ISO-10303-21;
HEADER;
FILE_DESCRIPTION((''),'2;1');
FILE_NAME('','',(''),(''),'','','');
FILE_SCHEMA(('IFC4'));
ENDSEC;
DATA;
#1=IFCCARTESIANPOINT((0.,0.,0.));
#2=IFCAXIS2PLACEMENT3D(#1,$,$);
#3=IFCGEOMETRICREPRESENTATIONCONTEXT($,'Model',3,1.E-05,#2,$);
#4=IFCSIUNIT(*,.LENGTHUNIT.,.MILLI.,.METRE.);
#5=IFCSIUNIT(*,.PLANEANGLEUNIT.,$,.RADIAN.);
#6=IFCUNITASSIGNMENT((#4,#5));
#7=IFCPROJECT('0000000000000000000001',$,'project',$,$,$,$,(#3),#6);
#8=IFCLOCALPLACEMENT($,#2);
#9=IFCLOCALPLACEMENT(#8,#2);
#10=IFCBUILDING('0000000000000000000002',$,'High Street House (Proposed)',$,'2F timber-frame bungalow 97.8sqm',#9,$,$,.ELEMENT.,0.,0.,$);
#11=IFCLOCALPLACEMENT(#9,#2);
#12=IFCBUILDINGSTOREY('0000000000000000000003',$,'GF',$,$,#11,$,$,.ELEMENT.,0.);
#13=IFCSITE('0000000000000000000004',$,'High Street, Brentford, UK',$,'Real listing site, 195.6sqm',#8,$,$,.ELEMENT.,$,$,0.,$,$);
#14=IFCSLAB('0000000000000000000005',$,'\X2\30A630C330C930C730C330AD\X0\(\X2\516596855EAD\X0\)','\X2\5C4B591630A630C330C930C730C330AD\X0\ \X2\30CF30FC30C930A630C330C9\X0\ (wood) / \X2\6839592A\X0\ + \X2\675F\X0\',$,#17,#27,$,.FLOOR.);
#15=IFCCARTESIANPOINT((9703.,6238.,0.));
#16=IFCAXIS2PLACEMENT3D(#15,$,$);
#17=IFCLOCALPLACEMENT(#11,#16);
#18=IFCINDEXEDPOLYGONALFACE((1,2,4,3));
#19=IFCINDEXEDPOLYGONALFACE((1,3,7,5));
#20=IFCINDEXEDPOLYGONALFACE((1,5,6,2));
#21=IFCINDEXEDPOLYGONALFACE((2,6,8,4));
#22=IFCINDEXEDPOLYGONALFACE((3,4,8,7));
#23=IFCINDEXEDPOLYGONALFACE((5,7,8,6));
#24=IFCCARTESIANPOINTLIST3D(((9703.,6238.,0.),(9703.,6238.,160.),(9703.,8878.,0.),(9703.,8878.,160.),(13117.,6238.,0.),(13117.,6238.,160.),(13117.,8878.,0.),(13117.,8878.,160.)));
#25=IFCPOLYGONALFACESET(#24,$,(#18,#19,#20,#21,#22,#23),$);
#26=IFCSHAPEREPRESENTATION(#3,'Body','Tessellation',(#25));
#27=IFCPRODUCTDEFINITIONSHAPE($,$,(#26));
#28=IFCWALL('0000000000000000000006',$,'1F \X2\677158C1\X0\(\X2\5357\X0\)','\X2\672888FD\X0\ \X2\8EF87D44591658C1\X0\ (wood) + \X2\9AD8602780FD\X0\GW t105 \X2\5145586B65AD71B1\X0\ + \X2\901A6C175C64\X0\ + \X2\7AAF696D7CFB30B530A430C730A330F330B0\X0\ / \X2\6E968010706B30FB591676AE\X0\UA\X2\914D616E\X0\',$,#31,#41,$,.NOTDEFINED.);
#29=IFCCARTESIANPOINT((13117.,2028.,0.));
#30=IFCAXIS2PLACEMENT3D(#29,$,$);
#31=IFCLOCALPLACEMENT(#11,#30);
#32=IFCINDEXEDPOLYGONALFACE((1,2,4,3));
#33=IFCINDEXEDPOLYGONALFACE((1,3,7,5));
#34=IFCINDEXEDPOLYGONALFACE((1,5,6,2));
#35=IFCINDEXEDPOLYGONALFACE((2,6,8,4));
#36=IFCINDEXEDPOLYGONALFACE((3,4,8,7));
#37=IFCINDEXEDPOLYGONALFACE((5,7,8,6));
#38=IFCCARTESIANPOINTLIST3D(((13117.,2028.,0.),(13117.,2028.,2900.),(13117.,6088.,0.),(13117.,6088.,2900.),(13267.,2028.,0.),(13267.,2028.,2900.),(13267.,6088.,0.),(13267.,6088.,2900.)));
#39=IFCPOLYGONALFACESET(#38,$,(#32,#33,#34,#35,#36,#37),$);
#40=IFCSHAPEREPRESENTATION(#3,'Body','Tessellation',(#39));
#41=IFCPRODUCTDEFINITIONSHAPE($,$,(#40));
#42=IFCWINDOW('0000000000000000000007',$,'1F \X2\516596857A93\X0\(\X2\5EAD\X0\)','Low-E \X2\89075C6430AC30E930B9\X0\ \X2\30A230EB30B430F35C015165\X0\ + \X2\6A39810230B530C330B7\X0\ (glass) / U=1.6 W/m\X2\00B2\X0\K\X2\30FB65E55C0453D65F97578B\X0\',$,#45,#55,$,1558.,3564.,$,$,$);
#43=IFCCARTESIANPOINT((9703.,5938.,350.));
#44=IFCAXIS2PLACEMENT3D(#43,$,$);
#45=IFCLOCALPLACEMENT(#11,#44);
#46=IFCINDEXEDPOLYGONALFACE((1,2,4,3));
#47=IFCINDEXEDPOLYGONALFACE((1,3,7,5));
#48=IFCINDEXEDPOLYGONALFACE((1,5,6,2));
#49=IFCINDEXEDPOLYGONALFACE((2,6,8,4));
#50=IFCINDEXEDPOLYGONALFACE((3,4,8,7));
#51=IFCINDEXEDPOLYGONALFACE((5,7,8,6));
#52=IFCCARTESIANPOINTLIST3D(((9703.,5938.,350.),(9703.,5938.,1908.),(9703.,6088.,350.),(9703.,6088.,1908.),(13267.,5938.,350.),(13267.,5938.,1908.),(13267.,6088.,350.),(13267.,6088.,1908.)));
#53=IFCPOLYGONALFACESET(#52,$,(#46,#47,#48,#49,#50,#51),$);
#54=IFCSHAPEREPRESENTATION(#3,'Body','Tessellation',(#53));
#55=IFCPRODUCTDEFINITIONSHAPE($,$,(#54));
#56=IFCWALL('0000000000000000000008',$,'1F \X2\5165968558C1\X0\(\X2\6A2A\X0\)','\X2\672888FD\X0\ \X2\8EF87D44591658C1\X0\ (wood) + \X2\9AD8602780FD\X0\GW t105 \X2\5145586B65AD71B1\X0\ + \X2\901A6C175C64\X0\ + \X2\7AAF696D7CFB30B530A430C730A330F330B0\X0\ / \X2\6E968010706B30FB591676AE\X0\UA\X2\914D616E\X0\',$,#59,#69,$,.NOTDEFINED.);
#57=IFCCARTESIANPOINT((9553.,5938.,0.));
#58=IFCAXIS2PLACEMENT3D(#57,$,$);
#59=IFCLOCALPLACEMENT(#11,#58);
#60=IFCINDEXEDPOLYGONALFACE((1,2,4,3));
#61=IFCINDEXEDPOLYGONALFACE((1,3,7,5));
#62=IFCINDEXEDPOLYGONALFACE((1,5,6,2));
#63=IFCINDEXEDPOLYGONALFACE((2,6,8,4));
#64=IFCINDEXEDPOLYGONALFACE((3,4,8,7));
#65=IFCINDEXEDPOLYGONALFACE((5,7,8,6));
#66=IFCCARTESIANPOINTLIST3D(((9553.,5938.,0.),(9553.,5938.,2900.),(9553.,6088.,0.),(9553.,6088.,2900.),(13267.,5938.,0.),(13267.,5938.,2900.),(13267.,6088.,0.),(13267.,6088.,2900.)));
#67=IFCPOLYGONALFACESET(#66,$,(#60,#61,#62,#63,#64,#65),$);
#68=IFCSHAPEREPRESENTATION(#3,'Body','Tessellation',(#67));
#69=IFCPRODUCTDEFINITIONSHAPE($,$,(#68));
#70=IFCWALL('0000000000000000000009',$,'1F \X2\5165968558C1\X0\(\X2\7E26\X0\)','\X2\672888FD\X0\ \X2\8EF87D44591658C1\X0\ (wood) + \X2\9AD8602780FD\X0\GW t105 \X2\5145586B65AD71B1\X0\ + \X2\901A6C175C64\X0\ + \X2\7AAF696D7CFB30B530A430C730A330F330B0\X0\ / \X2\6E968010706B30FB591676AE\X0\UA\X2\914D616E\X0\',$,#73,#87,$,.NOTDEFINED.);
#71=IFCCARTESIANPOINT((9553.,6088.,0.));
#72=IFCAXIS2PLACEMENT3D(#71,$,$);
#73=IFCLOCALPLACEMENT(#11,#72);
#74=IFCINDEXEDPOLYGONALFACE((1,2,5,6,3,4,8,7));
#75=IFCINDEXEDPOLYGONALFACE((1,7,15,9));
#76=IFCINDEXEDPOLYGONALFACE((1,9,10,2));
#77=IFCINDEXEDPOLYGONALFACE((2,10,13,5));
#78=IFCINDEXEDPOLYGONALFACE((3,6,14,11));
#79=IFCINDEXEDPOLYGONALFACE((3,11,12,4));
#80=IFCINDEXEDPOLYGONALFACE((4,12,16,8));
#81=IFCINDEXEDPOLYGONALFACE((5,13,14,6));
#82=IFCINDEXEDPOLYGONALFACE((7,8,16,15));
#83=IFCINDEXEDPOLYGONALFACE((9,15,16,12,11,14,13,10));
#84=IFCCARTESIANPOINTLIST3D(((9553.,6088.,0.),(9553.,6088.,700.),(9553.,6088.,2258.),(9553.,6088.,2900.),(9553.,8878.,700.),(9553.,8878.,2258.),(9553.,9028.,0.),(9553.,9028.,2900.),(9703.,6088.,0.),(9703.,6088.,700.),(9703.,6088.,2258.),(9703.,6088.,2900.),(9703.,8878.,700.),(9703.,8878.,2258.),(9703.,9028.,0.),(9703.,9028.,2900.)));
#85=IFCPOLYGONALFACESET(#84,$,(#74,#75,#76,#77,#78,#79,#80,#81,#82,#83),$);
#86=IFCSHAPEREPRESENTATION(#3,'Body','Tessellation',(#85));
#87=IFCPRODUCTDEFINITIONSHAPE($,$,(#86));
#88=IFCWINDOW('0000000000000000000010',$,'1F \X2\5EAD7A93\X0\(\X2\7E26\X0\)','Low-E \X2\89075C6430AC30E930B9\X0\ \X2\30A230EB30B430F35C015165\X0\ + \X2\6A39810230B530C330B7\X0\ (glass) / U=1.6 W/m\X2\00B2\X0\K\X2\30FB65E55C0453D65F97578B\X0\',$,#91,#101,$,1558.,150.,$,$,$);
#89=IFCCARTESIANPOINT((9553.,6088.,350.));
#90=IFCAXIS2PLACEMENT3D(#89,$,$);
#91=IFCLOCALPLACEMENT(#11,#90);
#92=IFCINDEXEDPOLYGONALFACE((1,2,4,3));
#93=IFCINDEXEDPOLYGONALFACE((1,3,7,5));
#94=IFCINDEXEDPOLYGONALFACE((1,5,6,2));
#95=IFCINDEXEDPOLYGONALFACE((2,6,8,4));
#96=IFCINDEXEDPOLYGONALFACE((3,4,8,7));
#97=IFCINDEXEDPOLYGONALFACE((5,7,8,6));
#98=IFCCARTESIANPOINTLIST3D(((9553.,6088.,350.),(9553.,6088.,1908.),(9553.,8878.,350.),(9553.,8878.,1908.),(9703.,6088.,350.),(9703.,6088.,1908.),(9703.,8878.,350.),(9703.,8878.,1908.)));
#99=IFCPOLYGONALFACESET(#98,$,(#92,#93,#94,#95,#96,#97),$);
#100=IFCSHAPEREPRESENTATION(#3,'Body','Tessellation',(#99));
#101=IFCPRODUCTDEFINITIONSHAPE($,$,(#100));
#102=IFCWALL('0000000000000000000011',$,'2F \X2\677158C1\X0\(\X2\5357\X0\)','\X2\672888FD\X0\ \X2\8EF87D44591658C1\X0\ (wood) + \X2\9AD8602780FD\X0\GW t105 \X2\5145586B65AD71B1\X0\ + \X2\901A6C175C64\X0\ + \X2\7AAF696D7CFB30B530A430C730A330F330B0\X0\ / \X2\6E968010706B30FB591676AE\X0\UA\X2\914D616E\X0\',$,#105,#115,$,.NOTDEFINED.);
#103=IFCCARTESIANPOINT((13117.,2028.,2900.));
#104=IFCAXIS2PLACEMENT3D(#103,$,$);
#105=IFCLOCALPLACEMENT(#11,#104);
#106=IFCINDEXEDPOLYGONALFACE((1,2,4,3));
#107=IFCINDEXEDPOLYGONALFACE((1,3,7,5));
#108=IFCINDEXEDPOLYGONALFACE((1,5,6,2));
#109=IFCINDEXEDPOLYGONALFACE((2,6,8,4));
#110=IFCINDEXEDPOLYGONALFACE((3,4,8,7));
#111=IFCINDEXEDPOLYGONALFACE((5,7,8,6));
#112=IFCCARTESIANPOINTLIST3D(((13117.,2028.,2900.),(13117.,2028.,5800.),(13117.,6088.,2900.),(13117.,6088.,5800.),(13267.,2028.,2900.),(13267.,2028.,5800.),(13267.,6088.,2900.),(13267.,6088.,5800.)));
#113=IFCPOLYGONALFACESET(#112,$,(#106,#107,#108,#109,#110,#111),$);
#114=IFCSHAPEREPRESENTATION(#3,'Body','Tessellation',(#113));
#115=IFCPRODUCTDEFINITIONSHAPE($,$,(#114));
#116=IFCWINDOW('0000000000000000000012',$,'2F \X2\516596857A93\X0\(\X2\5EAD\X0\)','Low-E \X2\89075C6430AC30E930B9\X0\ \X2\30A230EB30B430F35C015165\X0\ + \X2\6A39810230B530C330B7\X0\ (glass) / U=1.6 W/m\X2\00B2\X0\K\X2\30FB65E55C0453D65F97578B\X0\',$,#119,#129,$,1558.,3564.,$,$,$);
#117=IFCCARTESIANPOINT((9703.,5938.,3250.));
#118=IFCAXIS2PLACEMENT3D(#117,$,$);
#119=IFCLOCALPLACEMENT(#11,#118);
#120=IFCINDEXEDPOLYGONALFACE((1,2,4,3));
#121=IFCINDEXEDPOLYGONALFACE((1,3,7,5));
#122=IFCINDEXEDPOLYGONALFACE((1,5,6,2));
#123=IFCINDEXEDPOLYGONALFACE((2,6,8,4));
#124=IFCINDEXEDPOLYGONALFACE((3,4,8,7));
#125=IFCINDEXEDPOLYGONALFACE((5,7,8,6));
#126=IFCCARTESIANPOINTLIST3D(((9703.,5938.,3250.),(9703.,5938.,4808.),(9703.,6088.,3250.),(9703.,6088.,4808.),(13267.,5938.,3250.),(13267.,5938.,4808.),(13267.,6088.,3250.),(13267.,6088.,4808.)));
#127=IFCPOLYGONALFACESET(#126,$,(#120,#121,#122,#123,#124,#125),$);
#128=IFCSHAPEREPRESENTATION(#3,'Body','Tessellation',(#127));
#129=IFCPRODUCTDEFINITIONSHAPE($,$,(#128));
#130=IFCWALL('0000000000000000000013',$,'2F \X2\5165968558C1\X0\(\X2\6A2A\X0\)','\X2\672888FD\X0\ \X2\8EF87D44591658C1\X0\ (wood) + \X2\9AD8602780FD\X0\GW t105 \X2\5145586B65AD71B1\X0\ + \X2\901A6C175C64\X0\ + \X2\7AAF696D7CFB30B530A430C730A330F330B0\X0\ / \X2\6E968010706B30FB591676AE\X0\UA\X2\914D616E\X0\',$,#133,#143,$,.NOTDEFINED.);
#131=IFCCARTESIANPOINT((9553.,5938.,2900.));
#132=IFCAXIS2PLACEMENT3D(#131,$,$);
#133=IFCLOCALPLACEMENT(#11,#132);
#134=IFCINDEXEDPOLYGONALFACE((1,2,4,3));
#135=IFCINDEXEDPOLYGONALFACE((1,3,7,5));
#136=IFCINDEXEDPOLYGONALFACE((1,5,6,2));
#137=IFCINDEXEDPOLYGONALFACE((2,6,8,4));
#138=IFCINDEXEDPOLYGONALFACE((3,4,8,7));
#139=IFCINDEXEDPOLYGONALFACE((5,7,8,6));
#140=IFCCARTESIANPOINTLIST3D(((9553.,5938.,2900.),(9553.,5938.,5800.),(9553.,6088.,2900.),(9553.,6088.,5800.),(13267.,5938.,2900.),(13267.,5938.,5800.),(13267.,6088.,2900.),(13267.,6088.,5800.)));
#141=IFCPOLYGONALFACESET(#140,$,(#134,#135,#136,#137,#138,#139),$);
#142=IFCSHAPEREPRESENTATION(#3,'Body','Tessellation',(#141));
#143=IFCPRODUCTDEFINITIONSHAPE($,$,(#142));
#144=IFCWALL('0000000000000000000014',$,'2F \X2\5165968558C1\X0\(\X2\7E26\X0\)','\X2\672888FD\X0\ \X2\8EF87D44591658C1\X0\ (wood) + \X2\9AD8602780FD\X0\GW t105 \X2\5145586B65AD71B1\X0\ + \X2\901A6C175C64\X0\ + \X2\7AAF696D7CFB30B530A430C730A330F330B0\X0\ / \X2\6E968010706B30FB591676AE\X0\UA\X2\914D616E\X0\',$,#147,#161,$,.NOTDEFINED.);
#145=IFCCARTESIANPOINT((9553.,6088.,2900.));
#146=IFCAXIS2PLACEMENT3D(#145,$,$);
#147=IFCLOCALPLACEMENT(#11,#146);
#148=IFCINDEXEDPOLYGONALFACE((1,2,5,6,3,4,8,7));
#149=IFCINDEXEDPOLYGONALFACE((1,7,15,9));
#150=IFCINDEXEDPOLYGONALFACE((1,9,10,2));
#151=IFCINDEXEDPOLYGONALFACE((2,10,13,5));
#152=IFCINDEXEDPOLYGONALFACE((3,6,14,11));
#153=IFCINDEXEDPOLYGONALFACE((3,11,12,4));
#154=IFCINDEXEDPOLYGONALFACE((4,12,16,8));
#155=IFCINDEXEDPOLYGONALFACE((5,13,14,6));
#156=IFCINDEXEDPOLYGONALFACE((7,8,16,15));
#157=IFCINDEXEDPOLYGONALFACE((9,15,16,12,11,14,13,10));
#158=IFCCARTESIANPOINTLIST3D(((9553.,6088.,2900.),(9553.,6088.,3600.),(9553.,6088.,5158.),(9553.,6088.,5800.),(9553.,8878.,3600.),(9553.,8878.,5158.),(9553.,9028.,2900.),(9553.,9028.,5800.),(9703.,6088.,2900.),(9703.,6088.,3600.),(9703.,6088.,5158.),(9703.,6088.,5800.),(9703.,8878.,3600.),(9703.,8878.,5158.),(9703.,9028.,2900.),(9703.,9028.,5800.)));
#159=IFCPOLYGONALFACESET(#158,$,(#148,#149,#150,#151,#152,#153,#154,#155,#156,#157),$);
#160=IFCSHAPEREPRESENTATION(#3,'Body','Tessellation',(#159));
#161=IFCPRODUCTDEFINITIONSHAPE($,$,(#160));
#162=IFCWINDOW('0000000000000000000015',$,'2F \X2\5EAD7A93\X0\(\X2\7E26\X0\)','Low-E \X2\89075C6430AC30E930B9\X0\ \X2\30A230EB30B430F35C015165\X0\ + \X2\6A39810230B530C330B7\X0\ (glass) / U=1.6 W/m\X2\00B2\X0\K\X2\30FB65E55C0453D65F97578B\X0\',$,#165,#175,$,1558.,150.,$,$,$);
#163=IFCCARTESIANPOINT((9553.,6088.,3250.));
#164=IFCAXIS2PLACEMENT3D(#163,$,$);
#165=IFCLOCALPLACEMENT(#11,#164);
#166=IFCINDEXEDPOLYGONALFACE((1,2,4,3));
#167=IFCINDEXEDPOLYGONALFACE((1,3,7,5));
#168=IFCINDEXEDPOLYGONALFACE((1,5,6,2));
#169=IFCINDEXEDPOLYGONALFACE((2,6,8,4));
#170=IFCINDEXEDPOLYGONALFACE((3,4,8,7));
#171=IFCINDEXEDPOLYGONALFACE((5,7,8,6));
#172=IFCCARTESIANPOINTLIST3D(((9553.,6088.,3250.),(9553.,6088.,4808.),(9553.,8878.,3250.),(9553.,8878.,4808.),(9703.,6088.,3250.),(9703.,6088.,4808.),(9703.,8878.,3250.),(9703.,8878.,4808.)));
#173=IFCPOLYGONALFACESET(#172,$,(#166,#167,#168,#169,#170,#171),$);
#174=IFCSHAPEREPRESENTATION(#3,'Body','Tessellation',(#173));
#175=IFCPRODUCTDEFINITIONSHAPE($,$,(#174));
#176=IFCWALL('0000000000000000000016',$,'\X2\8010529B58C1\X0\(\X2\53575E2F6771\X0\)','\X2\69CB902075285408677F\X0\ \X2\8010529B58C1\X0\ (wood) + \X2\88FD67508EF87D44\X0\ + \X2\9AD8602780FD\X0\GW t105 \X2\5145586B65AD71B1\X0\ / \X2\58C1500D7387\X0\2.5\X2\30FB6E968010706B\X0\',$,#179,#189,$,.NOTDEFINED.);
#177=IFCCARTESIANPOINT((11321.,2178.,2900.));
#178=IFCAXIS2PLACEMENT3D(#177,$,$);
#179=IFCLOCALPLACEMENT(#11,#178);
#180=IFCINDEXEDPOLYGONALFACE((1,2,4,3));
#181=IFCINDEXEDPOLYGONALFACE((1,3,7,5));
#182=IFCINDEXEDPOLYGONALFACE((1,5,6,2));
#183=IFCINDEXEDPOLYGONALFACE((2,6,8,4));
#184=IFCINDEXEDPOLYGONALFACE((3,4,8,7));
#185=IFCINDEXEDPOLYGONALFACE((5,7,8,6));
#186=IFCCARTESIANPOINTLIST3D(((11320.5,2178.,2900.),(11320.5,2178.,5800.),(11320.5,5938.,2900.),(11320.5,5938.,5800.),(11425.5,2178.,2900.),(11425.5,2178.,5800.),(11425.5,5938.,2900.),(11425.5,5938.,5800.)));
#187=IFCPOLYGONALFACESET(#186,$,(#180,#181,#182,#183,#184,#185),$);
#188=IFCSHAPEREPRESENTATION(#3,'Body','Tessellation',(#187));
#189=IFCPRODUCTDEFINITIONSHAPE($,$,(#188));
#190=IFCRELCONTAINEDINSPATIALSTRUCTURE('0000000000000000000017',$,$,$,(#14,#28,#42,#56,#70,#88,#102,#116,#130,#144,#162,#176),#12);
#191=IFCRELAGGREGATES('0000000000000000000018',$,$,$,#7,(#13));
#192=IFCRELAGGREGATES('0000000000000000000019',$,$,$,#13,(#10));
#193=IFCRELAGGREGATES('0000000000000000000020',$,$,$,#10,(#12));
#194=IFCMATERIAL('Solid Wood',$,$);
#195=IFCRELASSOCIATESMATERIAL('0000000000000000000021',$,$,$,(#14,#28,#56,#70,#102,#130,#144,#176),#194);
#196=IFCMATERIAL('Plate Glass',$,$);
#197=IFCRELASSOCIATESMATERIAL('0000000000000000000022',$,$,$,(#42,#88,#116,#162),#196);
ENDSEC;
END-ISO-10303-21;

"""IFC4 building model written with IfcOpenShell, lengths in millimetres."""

from ifc_helpers import new_model, si_unit, frame, frame_2d, origin, place, context, project, spatial, rectangle, extrude, material, element, fill, save


model = new_model("IFC4")

# Units and contexts
model_context = context("Model", 3, precision=1e-05, world=origin())
ifc_project = project(units=[si_unit("LENGTHUNIT", "METRE", prefix="MILLI"), si_unit("PLANEANGLEUNIT", "RADIAN")], contexts=[model_context])

# Site, building, storey
site_placement = place(None, origin())
site = spatial("IfcSite", under=ifc_project, at=site_placement, Name="High Street, Brentford, UK", ObjectType="Real listing site, 195.6sqm", CompositionType="ELEMENT", RefElevation=0.0)
building_placement = place(site_placement, origin())
building = spatial("IfcBuilding", under=site, at=building_placement, Name="High Street House (Proposed)", ObjectType="2F timber-frame bungalow 97.8sqm", CompositionType="ELEMENT", ElevationOfRefHeight=0.0, ElevationOfTerrain=0.0)
storey_placement = place(building_placement, origin())
storey = spatial("IfcBuildingStorey", under=building, at=storey_placement, Name="GF", CompositionType="ELEMENT", Elevation=0.0)

# Slab
ifc_material_1 = material(Name="Solid Wood")
slab_placement = place(storey_placement, frame((9703.0, 6238.0, 0.0)))
element("IfcSlab", 1, at=slab_placement, inside=storey, material=ifc_material_1, Name="ウッドデッキ(入隅庭)", Description="屋外ウッドデッキ ハードウッド (wood) / 根太 + 束", PredefinedType="FLOOR", context=model_context, shape_type="SweptSolid", body=[
    extrude(rectangle(XDim=3414.0, YDim=2640.0, at=frame_2d((1707.0, 1320.0))), frame((9703.0, 6238.0, 0.0)), (0.0, 0.0, 1.0), 160.0),
])

# Wall, opening, window
wall_1_placement = place(storey_placement, frame((13117.0, 2028.0, 0.0)))
wall_1 = element("IfcWall", 2, at=wall_1_placement, inside=storey, material=ifc_material_1, Name="1F 東壁(南)", Description="木製 軸組外壁 (wood) + 高性能GW t105 充填断熱 + 通気層 + 窯業系サイディング / 準耐火・外皮UA配慮", PredefinedType="NOTDEFINED", context=model_context, shape_type="SweptSolid", body=[
    extrude(rectangle(XDim=150.0, YDim=4060.0, at=frame_2d((75.0, 2030.0))), frame((13117.0, 2028.0, 0.0)), (0.0, 0.0, 1.0), 2900.0),
])
opening_1_placement = place(storey_placement, frame((9703.0, 5938.0, 350.0)))
opening_1 = element("IfcOpeningElement", 3, at=opening_1_placement, cuts=wall_1, PredefinedType="NOTDEFINED", context=model_context, shape_type="SweptSolid", body=[
    extrude(rectangle(XDim=3564.0, YDim=150.0, at=frame_2d((1782.0, 75.0))), frame((9703.0, 5938.0, 350.0)), (0.0, 0.0, 1.0), 1558.0),
])
ifc_material_2 = material(Name="Plate Glass")
window_1_placement = place(storey_placement, frame((9703.0, 5938.0, 350.0)))
window_1 = element("IfcWindow", 4, at=window_1_placement, inside=storey, material=ifc_material_2, Name="1F 入隅窓(庭)", Description="Low-E 複層ガラス アルゴン封入 + 樹脂サッシ (glass) / U=1.6 W/m²K・日射取得型", OverallHeight=1558.0, OverallWidth=3564.0, context=model_context, shape_type="SweptSolid", body=[
    extrude(rectangle(XDim=3564.0, YDim=150.0, at=frame_2d((1782.0, 75.0))), frame((9703.0, 5938.0, 350.0)), (0.0, 0.0, 1.0), 1558.0),
])
fill(opening_1, window_1)

# Wall
wall_2_placement = place(storey_placement, frame((9553.0, 5938.0, 0.0)))
element("IfcWall", 5, at=wall_2_placement, inside=storey, material=ifc_material_1, Name="1F 入隅壁(横)", Description="木製 軸組外壁 (wood) + 高性能GW t105 充填断熱 + 通気層 + 窯業系サイディング / 準耐火・外皮UA配慮", PredefinedType="NOTDEFINED", context=model_context, shape_type="SweptSolid", body=[
    extrude(rectangle(XDim=3714.0, YDim=150.0, at=frame_2d((1857.0, 75.0))), frame((9553.0, 5938.0, 0.0)), (0.0, 0.0, 1.0), 2900.0),
])

# Wall, opening, window
wall_3_placement = place(storey_placement, frame((9553.0, 6088.0, 0.0)))
wall_3 = element("IfcWall", 6, at=wall_3_placement, inside=storey, material=ifc_material_1, Name="1F 入隅壁(縦)", Description="木製 軸組外壁 (wood) + 高性能GW t105 充填断熱 + 通気層 + 窯業系サイディング / 準耐火・外皮UA配慮", PredefinedType="NOTDEFINED", context=model_context, shape_type="SweptSolid", body=[
    extrude(rectangle(XDim=150.0, YDim=2940.0, at=frame_2d((75.0, 1470.0))), frame((9553.0, 6088.0, 0.0)), (0.0, 0.0, 1.0), 2900.0),
])
opening_2_placement = place(storey_placement, frame((9553.0, 6088.0, 350.0)))
opening_2 = element("IfcOpeningElement", 7, at=opening_2_placement, cuts=wall_3, PredefinedType="NOTDEFINED", context=model_context, shape_type="SweptSolid", body=[
    extrude(rectangle(XDim=150.0, YDim=2790.0, at=frame_2d((75.0, 1395.0))), frame((9553.0, 6088.0, 350.0)), (0.0, 0.0, 1.0), 1558.0),
])
window_2_placement = place(storey_placement, frame((9553.0, 6088.0, 350.0)))
window_2 = element("IfcWindow", 8, at=window_2_placement, inside=storey, material=ifc_material_2, Name="1F 庭窓(縦)", Description="Low-E 複層ガラス アルゴン封入 + 樹脂サッシ (glass) / U=1.6 W/m²K・日射取得型", OverallHeight=1558.0, OverallWidth=150.0, context=model_context, shape_type="SweptSolid", body=[
    extrude(rectangle(XDim=150.0, YDim=2790.0, at=frame_2d((75.0, 1395.0))), frame((9553.0, 6088.0, 350.0)), (0.0, 0.0, 1.0), 1558.0),
])
fill(opening_2, window_2)

# Wall, opening, window
wall_4_placement = place(storey_placement, frame((13117.0, 2028.0, 2900.0)))
wall_4 = element("IfcWall", 9, at=wall_4_placement, inside=storey, material=ifc_material_1, Name="2F 東壁(南)", Description="木製 軸組外壁 (wood) + 高性能GW t105 充填断熱 + 通気層 + 窯業系サイディング / 準耐火・外皮UA配慮", PredefinedType="NOTDEFINED", context=model_context, shape_type="SweptSolid", body=[
    extrude(rectangle(XDim=150.0, YDim=4060.0, at=frame_2d((75.0, 2030.0))), frame((13117.0, 2028.0, 2900.0)), (0.0, 0.0, 1.0), 2900.0),
])
opening_3_placement = place(storey_placement, frame((9703.0, 5938.0, 3250.0)))
opening_3 = element("IfcOpeningElement", 10, at=opening_3_placement, cuts=wall_4, PredefinedType="NOTDEFINED", context=model_context, shape_type="SweptSolid", body=[
    extrude(rectangle(XDim=3564.0, YDim=150.0, at=frame_2d((1782.0, 75.0))), frame((9703.0, 5938.0, 3250.0)), (0.0, 0.0, 1.0), 1558.0),
])
window_3_placement = place(storey_placement, frame((9703.0, 5938.0, 3250.0)))
window_3 = element("IfcWindow", 11, at=window_3_placement, inside=storey, material=ifc_material_2, Name="2F 入隅窓(庭)", Description="Low-E 複層ガラス アルゴン封入 + 樹脂サッシ (glass) / U=1.6 W/m²K・日射取得型", OverallHeight=1558.0, OverallWidth=3564.0, context=model_context, shape_type="SweptSolid", body=[
    extrude(rectangle(XDim=3564.0, YDim=150.0, at=frame_2d((1782.0, 75.0))), frame((9703.0, 5938.0, 3250.0)), (0.0, 0.0, 1.0), 1558.0),
])
fill(opening_3, window_3)

# Wall
wall_5_placement = place(storey_placement, frame((9553.0, 5938.0, 2900.0)))
element("IfcWall", 12, at=wall_5_placement, inside=storey, material=ifc_material_1, Name="2F 入隅壁(横)", Description="木製 軸組外壁 (wood) + 高性能GW t105 充填断熱 + 通気層 + 窯業系サイディング / 準耐火・外皮UA配慮", PredefinedType="NOTDEFINED", context=model_context, shape_type="SweptSolid", body=[
    extrude(rectangle(XDim=3714.0, YDim=150.0, at=frame_2d((1857.0, 75.0))), frame((9553.0, 5938.0, 2900.0)), (0.0, 0.0, 1.0), 2900.0),
])

# Wall, opening, window
wall_6_placement = place(storey_placement, frame((9553.0, 6088.0, 2900.0)))
wall_6 = element("IfcWall", 13, at=wall_6_placement, inside=storey, material=ifc_material_1, Name="2F 入隅壁(縦)", Description="木製 軸組外壁 (wood) + 高性能GW t105 充填断熱 + 通気層 + 窯業系サイディング / 準耐火・外皮UA配慮", PredefinedType="NOTDEFINED", context=model_context, shape_type="SweptSolid", body=[
    extrude(rectangle(XDim=150.0, YDim=2940.0, at=frame_2d((75.0, 1470.0))), frame((9553.0, 6088.0, 2900.0)), (0.0, 0.0, 1.0), 2900.0),
])
opening_4_placement = place(storey_placement, frame((9553.0, 6088.0, 3250.0)))
opening_4 = element("IfcOpeningElement", 14, at=opening_4_placement, cuts=wall_6, PredefinedType="NOTDEFINED", context=model_context, shape_type="SweptSolid", body=[
    extrude(rectangle(XDim=150.0, YDim=2790.0, at=frame_2d((75.0, 1395.0))), frame((9553.0, 6088.0, 3250.0)), (0.0, 0.0, 1.0), 1558.0),
])
window_4_placement = place(storey_placement, frame((9553.0, 6088.0, 3250.0)))
window_4 = element("IfcWindow", 15, at=window_4_placement, inside=storey, material=ifc_material_2, Name="2F 庭窓(縦)", Description="Low-E 複層ガラス アルゴン封入 + 樹脂サッシ (glass) / U=1.6 W/m²K・日射取得型", OverallHeight=1558.0, OverallWidth=150.0, context=model_context, shape_type="SweptSolid", body=[
    extrude(rectangle(XDim=150.0, YDim=2790.0, at=frame_2d((75.0, 1395.0))), frame((9553.0, 6088.0, 3250.0)), (0.0, 0.0, 1.0), 1558.0),
])
fill(opening_4, window_4)

# Wall
wall_7_placement = place(storey_placement, frame((11321.0, 2178.0, 2900.0)))
element("IfcWall", 16, at=wall_7_placement, inside=storey, material=ifc_material_1, Name="耐力壁(南帯東)", Description="構造用合板 耐力壁 (wood) + 製材軸組 + 高性能GW t105 充填断熱 / 壁倍率2.5・準耐火", PredefinedType="NOTDEFINED", context=model_context, shape_type="SweptSolid", body=[
    extrude(rectangle(XDim=105.0, YDim=3760.0, at=frame_2d((52.0, 1880.0))), frame((11321.0, 2178.0, 2900.0)), (0.0, 0.0, 1.0), 2900.0),
])

save(model, "model.ifc")
